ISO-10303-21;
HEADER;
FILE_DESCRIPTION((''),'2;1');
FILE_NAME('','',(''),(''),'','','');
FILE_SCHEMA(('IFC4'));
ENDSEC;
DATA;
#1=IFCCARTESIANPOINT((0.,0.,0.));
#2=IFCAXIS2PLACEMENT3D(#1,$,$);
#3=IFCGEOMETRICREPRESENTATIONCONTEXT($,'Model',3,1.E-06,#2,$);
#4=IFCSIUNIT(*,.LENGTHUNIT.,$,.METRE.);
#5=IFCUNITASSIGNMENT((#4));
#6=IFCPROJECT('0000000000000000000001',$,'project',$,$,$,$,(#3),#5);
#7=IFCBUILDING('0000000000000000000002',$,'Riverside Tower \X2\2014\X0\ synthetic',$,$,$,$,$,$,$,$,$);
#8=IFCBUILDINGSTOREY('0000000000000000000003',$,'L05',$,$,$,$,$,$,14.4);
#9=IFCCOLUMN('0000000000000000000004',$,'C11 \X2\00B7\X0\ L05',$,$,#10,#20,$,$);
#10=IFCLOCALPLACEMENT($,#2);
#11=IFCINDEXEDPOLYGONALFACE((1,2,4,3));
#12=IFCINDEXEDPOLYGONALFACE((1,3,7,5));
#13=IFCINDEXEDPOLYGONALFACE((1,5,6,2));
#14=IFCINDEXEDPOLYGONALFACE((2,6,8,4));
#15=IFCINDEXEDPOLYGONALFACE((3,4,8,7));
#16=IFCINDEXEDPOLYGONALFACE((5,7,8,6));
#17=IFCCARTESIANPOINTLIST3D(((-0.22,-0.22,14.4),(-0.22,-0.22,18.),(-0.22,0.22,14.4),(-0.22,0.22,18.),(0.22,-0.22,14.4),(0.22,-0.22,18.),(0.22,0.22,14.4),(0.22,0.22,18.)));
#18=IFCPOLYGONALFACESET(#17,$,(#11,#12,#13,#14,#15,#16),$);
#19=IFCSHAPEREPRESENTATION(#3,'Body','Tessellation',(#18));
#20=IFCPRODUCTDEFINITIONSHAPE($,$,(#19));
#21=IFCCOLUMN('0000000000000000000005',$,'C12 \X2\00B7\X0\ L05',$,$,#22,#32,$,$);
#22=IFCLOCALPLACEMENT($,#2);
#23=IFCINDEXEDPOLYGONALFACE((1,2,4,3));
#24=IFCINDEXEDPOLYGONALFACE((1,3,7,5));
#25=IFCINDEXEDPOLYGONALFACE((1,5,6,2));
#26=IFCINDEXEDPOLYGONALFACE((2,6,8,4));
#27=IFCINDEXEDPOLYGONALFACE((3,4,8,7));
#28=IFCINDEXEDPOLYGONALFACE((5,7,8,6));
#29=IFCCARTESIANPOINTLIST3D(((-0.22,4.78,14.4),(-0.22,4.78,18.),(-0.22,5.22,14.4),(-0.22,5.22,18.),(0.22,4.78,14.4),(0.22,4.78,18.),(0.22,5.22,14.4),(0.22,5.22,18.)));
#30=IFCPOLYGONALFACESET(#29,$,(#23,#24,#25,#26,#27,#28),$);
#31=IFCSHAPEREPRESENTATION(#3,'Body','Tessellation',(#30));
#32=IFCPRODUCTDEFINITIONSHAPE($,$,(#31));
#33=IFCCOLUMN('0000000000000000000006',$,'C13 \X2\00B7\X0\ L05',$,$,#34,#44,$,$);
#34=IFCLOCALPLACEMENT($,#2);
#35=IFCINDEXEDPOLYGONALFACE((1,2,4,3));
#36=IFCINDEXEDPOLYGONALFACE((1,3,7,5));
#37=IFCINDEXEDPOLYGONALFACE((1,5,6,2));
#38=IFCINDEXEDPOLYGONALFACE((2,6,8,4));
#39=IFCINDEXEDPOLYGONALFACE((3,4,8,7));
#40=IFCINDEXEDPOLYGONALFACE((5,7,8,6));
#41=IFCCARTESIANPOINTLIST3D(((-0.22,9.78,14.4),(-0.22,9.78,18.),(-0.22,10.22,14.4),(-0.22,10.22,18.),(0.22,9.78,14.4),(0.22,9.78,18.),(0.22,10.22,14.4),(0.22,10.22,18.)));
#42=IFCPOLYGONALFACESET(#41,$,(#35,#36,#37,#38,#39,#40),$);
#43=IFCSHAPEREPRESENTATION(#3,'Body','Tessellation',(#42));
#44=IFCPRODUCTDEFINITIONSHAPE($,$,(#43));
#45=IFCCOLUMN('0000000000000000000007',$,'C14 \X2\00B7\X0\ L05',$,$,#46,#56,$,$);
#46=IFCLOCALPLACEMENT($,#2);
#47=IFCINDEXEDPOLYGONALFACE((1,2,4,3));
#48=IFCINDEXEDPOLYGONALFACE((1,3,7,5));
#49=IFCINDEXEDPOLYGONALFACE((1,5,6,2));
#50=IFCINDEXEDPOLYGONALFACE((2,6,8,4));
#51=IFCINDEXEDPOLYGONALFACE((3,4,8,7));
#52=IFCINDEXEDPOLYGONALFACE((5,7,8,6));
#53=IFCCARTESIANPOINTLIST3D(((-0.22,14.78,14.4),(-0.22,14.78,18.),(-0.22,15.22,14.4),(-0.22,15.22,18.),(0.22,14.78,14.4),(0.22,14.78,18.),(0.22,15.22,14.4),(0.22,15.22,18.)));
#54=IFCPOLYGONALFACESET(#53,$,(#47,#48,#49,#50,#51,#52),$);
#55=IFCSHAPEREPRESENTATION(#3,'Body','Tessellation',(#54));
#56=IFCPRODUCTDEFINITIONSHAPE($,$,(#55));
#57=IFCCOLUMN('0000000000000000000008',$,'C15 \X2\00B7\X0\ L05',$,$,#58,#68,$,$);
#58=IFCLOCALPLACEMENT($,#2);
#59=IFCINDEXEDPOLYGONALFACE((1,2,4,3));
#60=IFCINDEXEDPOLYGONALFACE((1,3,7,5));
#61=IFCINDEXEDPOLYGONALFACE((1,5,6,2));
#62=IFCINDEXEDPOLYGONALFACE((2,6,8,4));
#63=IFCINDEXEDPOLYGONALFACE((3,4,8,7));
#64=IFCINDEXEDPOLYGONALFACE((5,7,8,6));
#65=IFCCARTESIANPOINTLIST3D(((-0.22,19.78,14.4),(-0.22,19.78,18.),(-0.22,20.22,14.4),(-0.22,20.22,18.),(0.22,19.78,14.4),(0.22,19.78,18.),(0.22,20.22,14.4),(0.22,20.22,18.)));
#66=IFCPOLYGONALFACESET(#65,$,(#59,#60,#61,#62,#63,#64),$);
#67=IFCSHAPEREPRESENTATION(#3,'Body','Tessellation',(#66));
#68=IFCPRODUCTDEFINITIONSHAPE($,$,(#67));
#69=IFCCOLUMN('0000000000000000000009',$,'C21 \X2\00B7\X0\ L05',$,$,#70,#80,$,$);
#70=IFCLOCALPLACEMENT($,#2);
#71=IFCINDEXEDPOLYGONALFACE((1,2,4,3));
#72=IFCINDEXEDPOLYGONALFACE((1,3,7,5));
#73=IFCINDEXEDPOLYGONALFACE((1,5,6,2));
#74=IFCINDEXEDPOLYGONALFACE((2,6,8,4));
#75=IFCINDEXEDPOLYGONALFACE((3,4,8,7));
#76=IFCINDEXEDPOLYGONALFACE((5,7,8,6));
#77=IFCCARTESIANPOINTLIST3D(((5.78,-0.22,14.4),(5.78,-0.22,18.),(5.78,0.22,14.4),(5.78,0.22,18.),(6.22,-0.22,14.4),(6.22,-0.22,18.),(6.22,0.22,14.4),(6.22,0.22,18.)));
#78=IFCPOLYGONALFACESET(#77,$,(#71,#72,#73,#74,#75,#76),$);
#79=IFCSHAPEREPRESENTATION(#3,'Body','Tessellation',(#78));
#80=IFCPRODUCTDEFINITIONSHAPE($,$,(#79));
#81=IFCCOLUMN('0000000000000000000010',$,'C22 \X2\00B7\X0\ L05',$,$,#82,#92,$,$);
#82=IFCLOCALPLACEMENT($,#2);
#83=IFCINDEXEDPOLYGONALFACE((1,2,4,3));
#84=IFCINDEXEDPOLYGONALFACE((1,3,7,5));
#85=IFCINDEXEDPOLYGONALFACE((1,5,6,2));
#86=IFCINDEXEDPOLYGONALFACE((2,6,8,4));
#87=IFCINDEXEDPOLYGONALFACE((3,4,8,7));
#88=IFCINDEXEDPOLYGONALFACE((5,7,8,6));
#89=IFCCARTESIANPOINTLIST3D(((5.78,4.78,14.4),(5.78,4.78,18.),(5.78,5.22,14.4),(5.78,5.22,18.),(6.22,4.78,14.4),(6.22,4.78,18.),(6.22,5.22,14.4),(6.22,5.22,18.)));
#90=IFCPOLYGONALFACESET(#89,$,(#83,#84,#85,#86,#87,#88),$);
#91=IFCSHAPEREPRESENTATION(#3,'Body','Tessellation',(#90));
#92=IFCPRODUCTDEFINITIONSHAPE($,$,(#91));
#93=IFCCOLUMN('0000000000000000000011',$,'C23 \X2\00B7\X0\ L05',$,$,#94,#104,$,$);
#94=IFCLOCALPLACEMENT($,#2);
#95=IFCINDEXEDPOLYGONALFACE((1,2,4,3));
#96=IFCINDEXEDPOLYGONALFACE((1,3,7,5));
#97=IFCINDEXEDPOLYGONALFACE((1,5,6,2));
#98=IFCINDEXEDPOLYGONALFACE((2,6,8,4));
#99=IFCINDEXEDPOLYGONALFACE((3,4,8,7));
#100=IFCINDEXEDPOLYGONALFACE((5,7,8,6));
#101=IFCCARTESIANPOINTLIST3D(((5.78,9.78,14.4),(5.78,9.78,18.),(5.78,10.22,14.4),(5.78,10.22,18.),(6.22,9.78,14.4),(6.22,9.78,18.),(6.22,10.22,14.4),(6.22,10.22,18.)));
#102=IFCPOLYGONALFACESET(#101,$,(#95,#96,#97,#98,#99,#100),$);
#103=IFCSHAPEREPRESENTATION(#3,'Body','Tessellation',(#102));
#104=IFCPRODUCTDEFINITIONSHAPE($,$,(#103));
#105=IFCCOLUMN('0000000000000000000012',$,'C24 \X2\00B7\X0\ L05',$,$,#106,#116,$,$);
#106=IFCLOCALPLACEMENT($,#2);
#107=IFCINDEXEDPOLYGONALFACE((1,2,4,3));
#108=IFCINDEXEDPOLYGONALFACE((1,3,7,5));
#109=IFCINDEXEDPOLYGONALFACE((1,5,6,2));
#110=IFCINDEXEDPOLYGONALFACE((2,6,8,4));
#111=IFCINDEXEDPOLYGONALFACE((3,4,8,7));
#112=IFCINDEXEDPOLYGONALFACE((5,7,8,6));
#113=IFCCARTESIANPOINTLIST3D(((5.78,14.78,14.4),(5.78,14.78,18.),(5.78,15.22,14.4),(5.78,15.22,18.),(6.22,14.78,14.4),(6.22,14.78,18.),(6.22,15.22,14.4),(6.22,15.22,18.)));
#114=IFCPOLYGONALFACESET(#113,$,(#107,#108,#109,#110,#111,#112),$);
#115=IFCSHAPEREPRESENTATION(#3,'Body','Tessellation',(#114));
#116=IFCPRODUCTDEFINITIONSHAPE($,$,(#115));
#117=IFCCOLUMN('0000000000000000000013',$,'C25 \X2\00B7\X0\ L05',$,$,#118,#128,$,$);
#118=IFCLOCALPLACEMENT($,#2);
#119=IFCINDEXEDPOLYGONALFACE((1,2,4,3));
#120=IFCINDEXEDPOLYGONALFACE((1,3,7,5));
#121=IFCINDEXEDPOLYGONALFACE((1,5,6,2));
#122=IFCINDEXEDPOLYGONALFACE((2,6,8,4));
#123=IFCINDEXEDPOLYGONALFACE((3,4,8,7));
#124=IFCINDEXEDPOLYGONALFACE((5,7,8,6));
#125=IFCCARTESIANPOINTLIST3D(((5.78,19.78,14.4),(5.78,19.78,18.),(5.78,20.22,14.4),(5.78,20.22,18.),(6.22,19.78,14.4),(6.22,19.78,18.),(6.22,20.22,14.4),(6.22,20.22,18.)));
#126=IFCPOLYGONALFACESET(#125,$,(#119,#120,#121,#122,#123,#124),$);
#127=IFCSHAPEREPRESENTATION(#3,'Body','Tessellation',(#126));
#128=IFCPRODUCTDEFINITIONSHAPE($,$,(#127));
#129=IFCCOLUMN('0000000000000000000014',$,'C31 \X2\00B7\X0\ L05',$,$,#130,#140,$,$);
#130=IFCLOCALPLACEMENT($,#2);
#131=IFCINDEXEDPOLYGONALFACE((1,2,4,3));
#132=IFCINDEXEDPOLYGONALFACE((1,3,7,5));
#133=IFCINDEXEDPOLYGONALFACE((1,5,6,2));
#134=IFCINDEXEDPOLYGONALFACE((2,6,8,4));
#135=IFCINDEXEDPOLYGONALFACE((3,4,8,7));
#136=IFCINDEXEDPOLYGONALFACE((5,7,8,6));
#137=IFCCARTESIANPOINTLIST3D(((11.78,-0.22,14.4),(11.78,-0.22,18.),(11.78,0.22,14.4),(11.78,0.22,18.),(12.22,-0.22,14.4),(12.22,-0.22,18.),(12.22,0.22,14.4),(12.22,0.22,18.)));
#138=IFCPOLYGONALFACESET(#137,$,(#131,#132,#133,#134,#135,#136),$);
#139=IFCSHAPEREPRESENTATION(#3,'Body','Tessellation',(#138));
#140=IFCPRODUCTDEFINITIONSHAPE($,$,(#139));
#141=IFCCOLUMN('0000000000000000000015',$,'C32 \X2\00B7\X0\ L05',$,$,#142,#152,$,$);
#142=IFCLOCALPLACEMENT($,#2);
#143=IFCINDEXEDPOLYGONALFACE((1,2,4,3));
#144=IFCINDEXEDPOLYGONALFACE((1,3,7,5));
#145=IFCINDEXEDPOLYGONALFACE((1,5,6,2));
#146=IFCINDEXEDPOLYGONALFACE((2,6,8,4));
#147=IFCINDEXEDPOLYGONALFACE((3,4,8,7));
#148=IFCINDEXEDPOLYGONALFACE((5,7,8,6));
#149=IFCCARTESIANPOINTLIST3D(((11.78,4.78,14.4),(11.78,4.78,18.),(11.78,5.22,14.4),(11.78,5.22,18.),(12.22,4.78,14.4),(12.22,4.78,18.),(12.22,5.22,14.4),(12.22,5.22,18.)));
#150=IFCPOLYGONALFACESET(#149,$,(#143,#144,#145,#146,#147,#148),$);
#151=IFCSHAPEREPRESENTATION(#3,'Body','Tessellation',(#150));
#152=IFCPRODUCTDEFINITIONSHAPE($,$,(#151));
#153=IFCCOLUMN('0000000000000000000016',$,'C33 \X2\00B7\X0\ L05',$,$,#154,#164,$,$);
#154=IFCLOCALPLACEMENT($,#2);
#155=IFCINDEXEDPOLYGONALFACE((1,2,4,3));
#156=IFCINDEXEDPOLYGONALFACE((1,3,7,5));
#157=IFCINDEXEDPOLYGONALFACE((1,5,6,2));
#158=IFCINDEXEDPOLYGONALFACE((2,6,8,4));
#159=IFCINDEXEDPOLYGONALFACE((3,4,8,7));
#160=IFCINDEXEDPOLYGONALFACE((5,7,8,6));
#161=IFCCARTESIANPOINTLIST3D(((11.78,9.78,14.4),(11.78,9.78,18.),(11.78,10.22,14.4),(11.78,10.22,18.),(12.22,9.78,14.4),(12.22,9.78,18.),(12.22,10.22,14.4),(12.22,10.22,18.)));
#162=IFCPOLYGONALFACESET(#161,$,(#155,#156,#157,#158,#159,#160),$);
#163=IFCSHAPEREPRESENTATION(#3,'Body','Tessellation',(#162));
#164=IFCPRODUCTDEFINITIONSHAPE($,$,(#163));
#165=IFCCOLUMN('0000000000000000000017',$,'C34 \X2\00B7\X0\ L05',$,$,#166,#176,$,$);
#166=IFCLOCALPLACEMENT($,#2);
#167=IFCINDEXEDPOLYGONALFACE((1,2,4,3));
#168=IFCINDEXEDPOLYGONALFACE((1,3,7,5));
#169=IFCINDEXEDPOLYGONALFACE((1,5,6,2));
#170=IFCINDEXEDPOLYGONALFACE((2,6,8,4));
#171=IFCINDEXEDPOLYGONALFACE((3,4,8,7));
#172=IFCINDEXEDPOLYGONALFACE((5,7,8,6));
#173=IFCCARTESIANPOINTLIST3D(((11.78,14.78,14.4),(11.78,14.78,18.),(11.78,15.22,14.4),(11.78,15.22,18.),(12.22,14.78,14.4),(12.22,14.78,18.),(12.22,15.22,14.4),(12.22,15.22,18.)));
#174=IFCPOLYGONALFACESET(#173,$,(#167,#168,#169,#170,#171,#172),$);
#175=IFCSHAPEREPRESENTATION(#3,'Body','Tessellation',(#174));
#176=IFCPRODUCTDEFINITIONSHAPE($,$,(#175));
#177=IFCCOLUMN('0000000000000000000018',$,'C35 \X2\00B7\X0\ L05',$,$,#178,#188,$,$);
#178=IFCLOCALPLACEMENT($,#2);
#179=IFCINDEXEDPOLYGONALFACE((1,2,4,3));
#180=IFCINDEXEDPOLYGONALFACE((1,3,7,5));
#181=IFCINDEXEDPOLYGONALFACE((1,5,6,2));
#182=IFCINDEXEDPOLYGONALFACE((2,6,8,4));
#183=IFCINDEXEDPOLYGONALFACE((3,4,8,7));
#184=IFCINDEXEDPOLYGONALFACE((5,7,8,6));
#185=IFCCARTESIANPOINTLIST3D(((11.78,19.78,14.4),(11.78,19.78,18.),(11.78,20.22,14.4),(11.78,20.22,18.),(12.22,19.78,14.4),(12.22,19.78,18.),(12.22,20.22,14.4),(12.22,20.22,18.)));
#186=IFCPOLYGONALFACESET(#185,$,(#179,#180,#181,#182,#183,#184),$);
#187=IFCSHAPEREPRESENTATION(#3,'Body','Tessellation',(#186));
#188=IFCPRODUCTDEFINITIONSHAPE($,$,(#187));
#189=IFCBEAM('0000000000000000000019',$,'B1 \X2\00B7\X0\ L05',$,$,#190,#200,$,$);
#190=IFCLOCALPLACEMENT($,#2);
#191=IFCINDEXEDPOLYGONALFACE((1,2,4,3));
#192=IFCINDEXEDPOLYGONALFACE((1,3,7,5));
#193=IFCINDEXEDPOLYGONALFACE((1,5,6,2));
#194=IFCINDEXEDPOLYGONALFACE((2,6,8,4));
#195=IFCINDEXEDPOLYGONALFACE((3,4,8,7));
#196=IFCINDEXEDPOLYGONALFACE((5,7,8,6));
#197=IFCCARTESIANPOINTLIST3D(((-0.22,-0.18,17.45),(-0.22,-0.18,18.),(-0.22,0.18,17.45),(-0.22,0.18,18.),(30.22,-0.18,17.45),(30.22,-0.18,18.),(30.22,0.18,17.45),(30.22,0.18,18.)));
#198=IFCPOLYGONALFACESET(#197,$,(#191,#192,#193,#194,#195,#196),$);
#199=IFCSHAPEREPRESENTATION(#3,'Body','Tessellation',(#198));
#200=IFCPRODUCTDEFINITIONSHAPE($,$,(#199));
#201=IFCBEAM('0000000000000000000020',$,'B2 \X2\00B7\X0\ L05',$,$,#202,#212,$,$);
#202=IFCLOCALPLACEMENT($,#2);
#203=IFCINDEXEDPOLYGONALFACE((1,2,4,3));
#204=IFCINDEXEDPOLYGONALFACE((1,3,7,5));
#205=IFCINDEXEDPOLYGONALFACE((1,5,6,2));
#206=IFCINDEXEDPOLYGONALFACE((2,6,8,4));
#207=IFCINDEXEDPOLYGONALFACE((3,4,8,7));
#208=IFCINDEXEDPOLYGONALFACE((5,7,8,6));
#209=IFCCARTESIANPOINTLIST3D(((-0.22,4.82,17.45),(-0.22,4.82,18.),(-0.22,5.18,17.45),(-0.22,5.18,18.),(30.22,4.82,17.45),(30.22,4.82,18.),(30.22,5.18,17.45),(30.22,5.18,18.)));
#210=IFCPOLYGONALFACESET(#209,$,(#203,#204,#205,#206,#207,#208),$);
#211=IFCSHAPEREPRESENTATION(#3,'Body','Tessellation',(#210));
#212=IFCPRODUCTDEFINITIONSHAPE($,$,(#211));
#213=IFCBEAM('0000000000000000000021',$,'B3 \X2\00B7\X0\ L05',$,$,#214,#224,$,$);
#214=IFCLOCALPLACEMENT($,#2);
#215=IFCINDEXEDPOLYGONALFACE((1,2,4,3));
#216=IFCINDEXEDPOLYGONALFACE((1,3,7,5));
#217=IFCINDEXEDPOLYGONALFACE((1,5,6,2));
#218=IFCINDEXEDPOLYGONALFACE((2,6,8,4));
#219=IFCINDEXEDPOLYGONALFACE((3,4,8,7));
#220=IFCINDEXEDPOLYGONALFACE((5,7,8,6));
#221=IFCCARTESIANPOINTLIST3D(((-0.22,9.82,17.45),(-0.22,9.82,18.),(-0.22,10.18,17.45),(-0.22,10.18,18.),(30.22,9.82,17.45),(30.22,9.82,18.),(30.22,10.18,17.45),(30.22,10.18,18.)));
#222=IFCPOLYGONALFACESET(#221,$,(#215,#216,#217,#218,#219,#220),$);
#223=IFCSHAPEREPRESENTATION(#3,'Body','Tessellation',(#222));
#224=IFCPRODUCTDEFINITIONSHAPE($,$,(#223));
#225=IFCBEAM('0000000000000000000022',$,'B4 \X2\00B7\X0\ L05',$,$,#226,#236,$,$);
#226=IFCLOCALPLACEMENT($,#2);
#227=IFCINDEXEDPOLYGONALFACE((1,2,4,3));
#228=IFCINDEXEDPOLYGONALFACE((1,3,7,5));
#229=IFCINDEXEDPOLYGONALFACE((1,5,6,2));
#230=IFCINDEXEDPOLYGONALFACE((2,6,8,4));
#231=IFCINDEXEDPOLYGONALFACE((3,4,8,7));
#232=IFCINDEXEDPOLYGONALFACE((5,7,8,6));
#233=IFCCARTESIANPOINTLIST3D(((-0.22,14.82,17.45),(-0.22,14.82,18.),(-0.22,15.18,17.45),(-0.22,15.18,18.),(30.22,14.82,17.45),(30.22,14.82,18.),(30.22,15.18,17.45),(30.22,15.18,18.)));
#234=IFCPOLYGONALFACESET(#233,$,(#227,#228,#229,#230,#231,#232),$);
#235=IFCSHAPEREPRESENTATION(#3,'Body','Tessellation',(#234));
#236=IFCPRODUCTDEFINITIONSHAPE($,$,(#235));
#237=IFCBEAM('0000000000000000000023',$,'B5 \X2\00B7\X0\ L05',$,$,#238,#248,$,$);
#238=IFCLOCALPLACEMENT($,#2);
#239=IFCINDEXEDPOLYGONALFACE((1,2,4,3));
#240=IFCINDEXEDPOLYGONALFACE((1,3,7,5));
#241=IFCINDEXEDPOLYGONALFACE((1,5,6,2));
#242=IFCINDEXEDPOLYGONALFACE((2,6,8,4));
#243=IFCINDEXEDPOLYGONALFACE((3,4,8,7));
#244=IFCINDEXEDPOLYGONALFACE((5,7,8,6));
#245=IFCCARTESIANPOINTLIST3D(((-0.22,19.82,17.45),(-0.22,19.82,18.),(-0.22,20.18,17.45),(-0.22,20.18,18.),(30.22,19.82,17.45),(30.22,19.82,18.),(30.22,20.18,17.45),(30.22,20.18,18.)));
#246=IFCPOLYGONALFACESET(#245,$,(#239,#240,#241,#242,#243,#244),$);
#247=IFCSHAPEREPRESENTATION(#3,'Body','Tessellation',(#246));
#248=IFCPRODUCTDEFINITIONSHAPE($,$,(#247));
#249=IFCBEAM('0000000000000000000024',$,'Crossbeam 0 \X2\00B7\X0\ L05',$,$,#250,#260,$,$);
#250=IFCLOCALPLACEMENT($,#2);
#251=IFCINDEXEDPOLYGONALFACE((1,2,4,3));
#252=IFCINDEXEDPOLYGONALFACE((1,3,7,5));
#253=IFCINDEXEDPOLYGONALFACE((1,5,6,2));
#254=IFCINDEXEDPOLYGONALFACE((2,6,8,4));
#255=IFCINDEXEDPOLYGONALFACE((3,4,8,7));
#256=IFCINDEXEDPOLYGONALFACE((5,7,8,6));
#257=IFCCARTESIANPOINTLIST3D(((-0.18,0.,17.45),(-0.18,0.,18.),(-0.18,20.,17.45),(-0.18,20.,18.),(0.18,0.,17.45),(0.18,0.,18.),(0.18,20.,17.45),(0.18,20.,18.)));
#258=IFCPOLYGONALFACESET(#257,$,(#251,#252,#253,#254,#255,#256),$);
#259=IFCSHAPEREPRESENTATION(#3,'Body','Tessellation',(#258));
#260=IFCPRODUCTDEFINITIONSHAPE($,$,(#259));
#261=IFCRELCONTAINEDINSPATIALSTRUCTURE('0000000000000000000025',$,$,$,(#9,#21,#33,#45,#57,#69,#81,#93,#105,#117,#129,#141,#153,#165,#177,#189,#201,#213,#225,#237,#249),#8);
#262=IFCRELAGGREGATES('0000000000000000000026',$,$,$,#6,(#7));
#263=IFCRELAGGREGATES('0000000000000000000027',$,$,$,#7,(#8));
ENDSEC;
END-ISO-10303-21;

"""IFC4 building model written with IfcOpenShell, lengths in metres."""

from ifc_helpers import new_model, si_unit, frame, origin, place, context, project, spatial, rectangle, extrude, element, save


model = new_model("IFC4")

# Units and contexts
model_context = context("Model", 3, precision=1e-06, world=origin())
ifc_project = project(units=[si_unit("LENGTHUNIT", "METRE")], contexts=[model_context])

# Building, storey
building = spatial("IfcBuilding", under=ifc_project, Name="Riverside Tower — synthetic")
storey = spatial("IfcBuildingStorey", under=building, Name="L05", Elevation=14.4)

# Columns
for number, where, name in (
    (1, (0.0, 0.0, 14.4), "C11 · L05"),
    (2, (0.0, 5.0, 14.4), "C12 · L05"),
    (3, (0.0, 10.0, 14.4), "C13 · L05"),
    (4, (0.0, 15.0, 14.4), "C14 · L05"),
    (5, (0.0, 20.0, 14.4), "C15 · L05"),
    (6, (6.0, 0.0, 14.4), "C21 · L05"),
    (7, (6.0, 5.0, 14.4), "C22 · L05"),
    (8, (6.0, 10.0, 14.4), "C23 · L05"),
    (9, (6.0, 15.0, 14.4), "C24 · L05"),
    (10, (6.0, 20.0, 14.4), "C25 · L05"),
    (11, (12.0, 0.0, 14.4), "C31 · L05"),
    (12, (12.0, 5.0, 14.4), "C32 · L05"),
    (13, (12.0, 10.0, 14.4), "C33 · L05"),
    (14, (12.0, 15.0, 14.4), "C34 · L05"),
    (15, (12.0, 20.0, 14.4), "C35 · L05"),
):
    element("IfcColumn", number, at=place(None, frame(where)), inside=storey, Name=name, context=model_context, shape_type="SweptSolid", body=[
        extrude(rectangle(XDim=0.44, YDim=0.44), origin(), (0.0, 0.0, 1.0), 3.6),
    ])

# Beams
for number, where, name in (
    (16, (15.0, 0.0, 17.45), "B1 · L05"),
    (17, (15.0, 5.0, 17.45), "B2 · L05"),
    (18, (15.0, 10.0, 17.45), "B3 · L05"),
    (19, (15.0, 15.0, 17.45), "B4 · L05"),
    (20, (15.0, 20.0, 17.45), "B5 · L05"),
):
    element("IfcBeam", number, at=place(None, frame(where)), inside=storey, Name=name, context=model_context, shape_type="SweptSolid", body=[
        extrude(rectangle(XDim=30.44, YDim=0.36), origin(), (0.0, 0.0, 1.0), 0.55),
    ])
for number, where, name in (
    (21, (0.0, 10.0, 17.45), "Crossbeam 0 · L05"),
):
    element("IfcBeam", number, at=place(None, frame(where)), inside=storey, Name=name, context=model_context, shape_type="SweptSolid", body=[
        extrude(rectangle(XDim=0.36, YDim=20.0), origin(), (0.0, 0.0, 1.0), 0.55),
    ])

save(model, "model.ifc")
